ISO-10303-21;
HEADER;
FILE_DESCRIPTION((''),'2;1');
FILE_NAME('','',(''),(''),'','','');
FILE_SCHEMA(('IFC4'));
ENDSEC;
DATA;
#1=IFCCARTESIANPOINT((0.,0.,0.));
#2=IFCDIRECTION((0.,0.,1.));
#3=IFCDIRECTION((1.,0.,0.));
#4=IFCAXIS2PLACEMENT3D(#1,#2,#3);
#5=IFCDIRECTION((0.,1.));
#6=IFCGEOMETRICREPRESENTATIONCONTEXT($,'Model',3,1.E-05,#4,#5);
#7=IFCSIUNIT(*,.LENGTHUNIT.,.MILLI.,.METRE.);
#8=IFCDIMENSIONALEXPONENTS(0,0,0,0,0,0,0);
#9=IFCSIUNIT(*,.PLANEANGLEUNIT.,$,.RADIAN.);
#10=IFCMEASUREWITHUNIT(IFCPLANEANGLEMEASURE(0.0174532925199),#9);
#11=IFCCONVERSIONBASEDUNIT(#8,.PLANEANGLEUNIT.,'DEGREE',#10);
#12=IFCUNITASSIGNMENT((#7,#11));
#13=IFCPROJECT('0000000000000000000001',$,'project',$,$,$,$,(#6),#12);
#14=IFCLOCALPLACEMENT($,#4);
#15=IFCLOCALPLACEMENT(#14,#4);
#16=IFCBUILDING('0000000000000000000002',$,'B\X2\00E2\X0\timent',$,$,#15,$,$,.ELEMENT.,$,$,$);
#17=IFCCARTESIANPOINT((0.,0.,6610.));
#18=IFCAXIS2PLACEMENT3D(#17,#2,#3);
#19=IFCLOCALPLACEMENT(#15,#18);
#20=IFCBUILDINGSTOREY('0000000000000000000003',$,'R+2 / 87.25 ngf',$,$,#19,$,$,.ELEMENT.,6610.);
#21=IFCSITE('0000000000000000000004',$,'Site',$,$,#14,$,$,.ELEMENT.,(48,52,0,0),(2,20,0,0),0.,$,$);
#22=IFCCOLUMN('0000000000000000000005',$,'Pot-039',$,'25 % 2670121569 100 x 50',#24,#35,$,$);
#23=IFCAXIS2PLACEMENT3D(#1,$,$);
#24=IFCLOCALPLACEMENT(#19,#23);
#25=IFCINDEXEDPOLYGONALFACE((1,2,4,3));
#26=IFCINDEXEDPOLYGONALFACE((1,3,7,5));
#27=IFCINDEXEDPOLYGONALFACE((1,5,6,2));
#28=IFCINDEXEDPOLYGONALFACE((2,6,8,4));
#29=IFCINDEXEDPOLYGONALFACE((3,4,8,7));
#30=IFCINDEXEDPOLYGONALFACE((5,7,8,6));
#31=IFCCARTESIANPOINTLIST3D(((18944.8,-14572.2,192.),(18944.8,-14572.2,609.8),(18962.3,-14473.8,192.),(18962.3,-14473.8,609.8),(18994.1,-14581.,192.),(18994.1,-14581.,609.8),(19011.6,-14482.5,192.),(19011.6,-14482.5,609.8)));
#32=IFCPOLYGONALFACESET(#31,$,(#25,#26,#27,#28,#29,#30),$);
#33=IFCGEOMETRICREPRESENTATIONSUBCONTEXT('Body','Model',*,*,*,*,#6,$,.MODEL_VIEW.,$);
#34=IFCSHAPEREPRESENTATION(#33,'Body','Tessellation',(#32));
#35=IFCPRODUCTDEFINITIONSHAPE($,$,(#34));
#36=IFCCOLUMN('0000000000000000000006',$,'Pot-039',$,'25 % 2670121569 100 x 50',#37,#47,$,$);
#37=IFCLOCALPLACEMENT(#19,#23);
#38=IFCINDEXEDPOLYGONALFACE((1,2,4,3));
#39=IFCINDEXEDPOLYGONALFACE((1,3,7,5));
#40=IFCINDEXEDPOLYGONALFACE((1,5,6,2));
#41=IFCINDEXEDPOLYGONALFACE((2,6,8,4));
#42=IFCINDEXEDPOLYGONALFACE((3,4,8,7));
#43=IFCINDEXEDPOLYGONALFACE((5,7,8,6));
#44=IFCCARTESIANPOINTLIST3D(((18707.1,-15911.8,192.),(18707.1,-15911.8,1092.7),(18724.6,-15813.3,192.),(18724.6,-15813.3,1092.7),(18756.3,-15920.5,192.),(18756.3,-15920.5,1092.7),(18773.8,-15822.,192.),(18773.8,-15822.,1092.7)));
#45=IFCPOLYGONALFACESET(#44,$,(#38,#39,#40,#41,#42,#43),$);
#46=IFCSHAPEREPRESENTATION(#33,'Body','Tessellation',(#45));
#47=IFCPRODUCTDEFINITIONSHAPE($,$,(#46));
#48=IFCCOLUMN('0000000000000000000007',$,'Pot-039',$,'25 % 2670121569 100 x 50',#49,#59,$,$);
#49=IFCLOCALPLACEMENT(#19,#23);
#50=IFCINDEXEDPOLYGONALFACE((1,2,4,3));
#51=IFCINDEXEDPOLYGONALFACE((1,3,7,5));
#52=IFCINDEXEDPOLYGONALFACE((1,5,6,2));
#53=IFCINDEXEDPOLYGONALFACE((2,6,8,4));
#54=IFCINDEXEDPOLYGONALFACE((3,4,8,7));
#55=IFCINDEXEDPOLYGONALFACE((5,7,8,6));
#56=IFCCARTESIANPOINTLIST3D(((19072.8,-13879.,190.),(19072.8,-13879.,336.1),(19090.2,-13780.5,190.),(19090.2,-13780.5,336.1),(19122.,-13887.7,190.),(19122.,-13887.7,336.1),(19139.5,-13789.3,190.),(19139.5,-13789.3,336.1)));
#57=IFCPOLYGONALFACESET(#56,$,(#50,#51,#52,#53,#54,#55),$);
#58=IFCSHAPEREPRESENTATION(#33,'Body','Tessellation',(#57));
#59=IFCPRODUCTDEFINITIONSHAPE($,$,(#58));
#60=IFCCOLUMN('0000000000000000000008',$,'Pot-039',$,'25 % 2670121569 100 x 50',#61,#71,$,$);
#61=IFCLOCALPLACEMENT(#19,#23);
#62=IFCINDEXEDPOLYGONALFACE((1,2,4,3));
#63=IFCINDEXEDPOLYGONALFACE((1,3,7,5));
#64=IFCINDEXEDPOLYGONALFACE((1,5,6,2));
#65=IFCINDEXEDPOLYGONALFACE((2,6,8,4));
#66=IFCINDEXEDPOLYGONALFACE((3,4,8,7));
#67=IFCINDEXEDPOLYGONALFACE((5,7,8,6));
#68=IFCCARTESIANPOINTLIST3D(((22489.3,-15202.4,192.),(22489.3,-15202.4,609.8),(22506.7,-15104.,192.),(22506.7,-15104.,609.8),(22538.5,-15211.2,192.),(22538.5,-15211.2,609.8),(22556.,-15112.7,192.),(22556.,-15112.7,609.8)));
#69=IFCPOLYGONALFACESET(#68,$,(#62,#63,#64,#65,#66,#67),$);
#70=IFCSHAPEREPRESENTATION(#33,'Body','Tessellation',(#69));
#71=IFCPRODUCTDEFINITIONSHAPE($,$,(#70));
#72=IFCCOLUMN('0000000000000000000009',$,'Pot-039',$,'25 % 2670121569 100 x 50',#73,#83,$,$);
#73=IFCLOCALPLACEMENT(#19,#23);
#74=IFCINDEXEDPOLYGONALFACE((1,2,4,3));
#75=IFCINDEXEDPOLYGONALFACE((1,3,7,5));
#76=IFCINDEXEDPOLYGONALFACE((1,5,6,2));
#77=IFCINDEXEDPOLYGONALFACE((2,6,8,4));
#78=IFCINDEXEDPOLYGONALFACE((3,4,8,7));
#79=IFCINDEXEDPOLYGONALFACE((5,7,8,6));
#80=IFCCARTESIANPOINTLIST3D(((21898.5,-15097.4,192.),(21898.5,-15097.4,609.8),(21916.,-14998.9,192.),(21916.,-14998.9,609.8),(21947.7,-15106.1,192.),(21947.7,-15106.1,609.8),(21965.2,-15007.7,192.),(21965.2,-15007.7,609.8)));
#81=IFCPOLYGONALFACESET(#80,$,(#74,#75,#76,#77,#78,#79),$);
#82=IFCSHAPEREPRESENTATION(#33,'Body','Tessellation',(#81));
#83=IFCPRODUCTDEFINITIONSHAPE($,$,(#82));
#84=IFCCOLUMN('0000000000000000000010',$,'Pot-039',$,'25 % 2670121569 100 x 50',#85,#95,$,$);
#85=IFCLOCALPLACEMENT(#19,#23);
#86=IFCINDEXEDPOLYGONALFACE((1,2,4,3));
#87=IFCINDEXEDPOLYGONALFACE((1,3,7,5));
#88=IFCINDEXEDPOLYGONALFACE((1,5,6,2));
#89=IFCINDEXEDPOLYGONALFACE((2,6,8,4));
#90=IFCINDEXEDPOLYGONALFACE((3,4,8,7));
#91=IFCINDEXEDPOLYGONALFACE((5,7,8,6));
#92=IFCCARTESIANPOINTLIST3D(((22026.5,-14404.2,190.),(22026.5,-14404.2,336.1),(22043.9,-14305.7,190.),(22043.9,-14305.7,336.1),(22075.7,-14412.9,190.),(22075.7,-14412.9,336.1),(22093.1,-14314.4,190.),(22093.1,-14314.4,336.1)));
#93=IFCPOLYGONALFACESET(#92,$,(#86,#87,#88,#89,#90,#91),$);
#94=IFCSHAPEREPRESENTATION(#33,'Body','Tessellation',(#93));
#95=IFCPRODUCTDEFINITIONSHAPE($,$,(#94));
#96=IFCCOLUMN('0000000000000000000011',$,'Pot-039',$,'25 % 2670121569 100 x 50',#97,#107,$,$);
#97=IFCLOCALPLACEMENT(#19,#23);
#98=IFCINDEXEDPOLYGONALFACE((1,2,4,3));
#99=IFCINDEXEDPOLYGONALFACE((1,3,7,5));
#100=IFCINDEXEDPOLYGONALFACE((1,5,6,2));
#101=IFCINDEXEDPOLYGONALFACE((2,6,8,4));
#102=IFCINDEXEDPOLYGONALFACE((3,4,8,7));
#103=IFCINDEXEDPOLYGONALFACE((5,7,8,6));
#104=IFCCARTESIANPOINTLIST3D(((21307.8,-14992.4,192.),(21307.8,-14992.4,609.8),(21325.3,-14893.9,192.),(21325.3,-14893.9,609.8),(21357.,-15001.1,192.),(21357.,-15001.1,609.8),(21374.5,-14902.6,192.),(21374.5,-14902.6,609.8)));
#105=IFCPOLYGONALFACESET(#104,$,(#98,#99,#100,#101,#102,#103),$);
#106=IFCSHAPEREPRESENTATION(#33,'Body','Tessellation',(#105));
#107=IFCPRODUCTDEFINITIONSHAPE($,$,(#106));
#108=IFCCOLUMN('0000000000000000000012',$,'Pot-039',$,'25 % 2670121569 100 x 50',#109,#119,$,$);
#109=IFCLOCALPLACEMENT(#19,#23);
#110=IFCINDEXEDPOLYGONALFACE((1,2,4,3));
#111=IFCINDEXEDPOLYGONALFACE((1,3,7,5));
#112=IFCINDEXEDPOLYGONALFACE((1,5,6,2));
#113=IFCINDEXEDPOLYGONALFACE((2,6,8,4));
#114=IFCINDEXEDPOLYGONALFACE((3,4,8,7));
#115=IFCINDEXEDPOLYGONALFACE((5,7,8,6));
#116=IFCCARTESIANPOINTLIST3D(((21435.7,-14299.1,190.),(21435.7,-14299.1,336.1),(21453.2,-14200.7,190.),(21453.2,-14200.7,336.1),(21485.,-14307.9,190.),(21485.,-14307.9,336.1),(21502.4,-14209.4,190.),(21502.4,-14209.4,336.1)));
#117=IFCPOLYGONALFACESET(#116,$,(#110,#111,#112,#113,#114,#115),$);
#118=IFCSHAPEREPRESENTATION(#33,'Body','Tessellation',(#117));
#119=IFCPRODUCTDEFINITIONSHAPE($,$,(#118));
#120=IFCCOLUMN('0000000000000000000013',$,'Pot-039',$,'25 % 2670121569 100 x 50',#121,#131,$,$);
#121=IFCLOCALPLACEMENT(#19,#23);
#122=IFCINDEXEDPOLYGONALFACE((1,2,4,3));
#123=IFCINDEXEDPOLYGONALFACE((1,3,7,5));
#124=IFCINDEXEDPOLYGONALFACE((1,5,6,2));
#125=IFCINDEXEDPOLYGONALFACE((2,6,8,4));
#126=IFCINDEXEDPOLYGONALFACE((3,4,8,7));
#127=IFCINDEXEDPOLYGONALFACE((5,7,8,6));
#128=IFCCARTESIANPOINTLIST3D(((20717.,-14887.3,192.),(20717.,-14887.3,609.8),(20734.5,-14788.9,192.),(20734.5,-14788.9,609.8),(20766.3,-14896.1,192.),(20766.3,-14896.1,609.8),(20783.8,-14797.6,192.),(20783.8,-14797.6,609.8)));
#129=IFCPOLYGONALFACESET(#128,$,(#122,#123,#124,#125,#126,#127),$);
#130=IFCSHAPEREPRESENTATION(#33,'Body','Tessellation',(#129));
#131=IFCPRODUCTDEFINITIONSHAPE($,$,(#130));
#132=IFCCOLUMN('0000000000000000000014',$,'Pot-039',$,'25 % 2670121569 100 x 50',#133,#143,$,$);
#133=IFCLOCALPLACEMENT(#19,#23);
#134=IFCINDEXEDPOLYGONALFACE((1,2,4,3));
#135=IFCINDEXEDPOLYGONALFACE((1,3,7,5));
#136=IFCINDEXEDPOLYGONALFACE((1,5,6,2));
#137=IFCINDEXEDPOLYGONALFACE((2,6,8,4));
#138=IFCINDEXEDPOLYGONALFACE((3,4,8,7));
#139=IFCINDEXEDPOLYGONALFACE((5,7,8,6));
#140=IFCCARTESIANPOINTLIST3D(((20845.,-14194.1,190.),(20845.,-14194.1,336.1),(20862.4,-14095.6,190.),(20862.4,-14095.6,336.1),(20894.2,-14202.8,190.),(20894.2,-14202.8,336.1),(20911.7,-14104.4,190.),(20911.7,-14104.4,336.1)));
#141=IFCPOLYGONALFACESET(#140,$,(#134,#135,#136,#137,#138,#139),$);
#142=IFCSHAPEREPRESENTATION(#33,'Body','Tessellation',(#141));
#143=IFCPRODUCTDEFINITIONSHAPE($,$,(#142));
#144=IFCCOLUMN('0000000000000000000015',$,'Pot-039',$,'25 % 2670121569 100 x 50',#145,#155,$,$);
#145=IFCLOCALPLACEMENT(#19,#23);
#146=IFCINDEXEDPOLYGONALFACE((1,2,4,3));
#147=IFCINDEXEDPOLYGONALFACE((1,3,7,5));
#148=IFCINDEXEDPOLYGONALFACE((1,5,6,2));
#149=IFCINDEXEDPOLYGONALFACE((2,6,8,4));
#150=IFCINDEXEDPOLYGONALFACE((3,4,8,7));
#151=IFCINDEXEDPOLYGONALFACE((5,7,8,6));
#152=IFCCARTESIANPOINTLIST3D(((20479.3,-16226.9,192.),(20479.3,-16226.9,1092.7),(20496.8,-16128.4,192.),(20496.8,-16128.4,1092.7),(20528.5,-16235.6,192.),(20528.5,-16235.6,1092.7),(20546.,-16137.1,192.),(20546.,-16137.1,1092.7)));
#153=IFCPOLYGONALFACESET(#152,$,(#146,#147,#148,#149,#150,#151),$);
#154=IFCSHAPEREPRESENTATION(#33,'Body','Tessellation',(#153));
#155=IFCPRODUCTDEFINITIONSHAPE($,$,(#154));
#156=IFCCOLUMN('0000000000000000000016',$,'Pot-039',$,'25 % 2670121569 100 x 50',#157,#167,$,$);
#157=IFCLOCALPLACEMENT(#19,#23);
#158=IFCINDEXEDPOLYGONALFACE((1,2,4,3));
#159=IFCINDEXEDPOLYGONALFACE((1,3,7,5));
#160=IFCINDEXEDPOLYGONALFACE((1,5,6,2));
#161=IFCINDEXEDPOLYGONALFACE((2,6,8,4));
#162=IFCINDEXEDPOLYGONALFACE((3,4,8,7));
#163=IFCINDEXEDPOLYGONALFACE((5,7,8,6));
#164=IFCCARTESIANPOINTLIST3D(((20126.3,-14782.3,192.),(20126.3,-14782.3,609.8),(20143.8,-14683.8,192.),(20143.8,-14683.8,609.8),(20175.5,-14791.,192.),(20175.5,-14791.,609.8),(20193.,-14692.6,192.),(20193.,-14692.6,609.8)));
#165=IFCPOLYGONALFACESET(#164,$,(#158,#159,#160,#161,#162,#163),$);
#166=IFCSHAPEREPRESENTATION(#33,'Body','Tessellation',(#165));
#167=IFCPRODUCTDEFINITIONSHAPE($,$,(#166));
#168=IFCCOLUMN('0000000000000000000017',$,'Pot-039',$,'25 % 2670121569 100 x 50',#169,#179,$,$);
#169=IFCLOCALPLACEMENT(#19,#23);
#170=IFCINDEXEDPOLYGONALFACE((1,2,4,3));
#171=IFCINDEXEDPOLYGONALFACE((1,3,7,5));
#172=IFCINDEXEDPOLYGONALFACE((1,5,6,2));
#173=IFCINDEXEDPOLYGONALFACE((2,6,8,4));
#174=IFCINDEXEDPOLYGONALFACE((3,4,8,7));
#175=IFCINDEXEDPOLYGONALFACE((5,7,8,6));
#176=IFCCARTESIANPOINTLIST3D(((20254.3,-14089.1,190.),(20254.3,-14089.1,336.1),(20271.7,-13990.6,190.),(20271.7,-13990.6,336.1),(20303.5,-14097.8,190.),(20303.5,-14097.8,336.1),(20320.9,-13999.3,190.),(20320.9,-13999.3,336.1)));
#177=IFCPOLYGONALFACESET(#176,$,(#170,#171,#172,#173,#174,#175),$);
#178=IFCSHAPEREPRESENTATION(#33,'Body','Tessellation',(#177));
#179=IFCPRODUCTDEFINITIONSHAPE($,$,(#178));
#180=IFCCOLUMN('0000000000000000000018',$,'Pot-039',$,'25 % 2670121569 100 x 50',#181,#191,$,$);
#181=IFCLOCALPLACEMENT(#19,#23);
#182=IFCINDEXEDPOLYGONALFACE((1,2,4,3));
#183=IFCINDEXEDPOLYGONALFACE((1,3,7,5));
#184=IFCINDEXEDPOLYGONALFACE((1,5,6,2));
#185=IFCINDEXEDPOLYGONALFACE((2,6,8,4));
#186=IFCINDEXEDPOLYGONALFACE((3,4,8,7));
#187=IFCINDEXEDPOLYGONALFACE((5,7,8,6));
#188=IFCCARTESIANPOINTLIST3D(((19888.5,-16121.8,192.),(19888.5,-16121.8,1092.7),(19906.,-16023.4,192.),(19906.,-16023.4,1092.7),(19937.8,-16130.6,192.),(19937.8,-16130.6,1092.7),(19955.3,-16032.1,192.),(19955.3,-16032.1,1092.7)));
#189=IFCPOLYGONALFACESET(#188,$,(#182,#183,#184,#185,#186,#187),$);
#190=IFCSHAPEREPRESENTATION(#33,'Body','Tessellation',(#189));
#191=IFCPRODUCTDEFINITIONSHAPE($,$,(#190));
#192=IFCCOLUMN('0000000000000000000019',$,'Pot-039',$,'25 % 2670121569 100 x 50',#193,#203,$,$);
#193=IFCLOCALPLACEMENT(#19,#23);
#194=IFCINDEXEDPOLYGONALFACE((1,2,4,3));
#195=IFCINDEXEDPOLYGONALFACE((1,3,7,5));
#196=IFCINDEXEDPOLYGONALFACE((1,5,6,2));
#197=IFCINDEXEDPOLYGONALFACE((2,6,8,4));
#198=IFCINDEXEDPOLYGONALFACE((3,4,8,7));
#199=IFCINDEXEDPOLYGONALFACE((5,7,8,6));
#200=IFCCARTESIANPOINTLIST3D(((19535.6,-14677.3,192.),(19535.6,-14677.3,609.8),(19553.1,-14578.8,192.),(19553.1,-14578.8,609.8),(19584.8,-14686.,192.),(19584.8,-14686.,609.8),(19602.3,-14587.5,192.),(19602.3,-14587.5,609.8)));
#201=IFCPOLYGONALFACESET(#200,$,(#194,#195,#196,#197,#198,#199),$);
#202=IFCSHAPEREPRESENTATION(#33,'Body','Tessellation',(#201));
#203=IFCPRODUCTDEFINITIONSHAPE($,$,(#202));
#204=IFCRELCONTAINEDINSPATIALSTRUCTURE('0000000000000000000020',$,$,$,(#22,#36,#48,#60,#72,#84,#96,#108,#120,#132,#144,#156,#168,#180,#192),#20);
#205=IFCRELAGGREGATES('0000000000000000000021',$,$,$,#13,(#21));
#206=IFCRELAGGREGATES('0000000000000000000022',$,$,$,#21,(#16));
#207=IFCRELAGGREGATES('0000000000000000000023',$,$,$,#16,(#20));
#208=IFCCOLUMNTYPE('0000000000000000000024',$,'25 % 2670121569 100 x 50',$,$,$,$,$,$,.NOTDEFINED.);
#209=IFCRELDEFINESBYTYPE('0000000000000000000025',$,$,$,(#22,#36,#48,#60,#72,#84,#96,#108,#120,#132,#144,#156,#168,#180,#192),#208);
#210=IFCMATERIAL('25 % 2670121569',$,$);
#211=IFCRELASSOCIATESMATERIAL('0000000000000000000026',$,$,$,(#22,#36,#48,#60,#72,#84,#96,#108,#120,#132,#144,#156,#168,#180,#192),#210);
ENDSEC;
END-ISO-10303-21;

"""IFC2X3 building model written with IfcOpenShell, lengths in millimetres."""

from ifc_helpers import new_model, entity, si_unit, converted_unit, direction, frame, origin_with_axes, origin_2d_with_axis, place, context, subcontext, project, spatial, rectangle, extrude, material, type_object, element, save


model = new_model("IFC2X3")

# Units and contexts
model_context = context("Model", 3, precision=1e-05, world=origin_with_axes(), true_north=direction((0.0, 1.0)))
body_context = subcontext(model_context, "Body", "Model", "MODEL_VIEW")
ifc_project = project(units=[si_unit("LENGTHUNIT", "METRE", prefix="MILLI"), converted_unit("PLANEANGLEUNIT", "DEGREE", entity("IfcPlaneAngleMeasure", 0.0174532925199), si_unit("PLANEANGLEUNIT", "RADIAN"), dimensions=[0, 0, 0, 0, 0, 0, 0])], contexts=[model_context])

# Site, building, storey
site_placement = place(None, origin_with_axes())
site = spatial("IfcSite", under=ifc_project, at=site_placement, Name="Site", CompositionType="ELEMENT", RefLatitude=(48, 52, 0, 0), RefLongitude=(2, 20, 0, 0), RefElevation=0.0)
building_placement = place(site_placement, origin_with_axes())
building = spatial("IfcBuilding", under=site, at=building_placement, Name="Bâtiment", CompositionType="ELEMENT")
storey_placement = place(building_placement, frame((0.0, 0.0, 6610.0), z_axis=(0.0, 0.0, 1.0), x_axis=(1.0, 0.0, 0.0)))
storey = spatial("IfcBuildingStorey", under=building, at=storey_placement, Name="R+2 / 87.25 ngf", CompositionType="ELEMENT", Elevation=6610.0)

# Columns
ifc_material_1 = material(Name="25 % 2670121569")
column_type = type_object("IfcColumnType", Name="25 % 2670121569 100 x 50", PredefinedType="NOTDEFINED")
column_1_placement = place(storey_placement, frame((18978.2, -14527.4, 192.0), z_axis=(0.0, 0.0, 1.0), x_axis=(0.17478, 0.984607, 0.0)))
element("IfcColumn", 1, at=column_1_placement, inside=storey, type_object=column_type, material=ifc_material_1, Name="Pot-039", ObjectType="25 % 2670121569 100 x 50", context=body_context, shape_type="SweptSolid", body=[
    extrude(rectangle(XDim=100.0, YDim=50.0, at=origin_2d_with_axis()), origin_with_axes(), (0.0, 0.0, 1.0), 417.8),
])
column_2_placement = place(storey_placement, frame((18740.4, -15866.9, 192.0), z_axis=(0.0, 0.0, 1.0), x_axis=(0.17478, 0.984607, 0.0)))
element("IfcColumn", 2, at=column_2_placement, inside=storey, type_object=column_type, material=ifc_material_1, Name="Pot-039", ObjectType="25 % 2670121569 100 x 50", context=body_context, shape_type="SweptSolid", body=[
    extrude(rectangle(XDim=100.0, YDim=50.0, at=origin_2d_with_axis()), origin_with_axes(), (0.0, 0.0, 1.0), 900.7),
])
column_3_placement = place(storey_placement, frame((19106.1, -13834.1, 190.0), z_axis=(0.0, 0.0, 1.0), x_axis=(0.174407, 0.984674, 0.0)))
element("IfcColumn", 3, at=column_3_placement, inside=storey, type_object=column_type, material=ifc_material_1, Name="Pot-039", ObjectType="25 % 2670121569 100 x 50", context=body_context, shape_type="SweptSolid", body=[
    extrude(rectangle(XDim=100.0, YDim=50.0, at=origin_2d_with_axis()), origin_with_axes(), (0.0, 0.0, 1.0), 146.1),
])
for number, where, z_axis, x_axis, name in (
    (4, (22522.6, -15157.6, 192.0), (0.0, 0.0, 1.0), (0.17478, 0.984607, 0.0), "Pot-039"),
    (5, (21931.9, -15052.5, 192.0), (0.0, 0.0, 1.0), (0.17478, 0.984607, 0.0), "Pot-039"),
):
    element("IfcColumn", number, at=place(storey_placement, frame(where, z_axis=z_axis, x_axis=x_axis)), inside=storey, type_object=column_type, material=ifc_material_1, Name=name, ObjectType="25 % 2670121569 100 x 50", context=body_context, shape_type="SweptSolid", body=[
        extrude(rectangle(XDim=100.0, YDim=50.0, at=origin_2d_with_axis()), origin_with_axes(), (0.0, 0.0, 1.0), 417.8),
    ])
column_4_placement = place(storey_placement, frame((22059.8, -14359.3, 190.0), z_axis=(0.0, 0.0, 1.0), x_axis=(0.174407, 0.984674, 0.0)))
element("IfcColumn", 6, at=column_4_placement, inside=storey, type_object=column_type, material=ifc_material_1, Name="Pot-039", ObjectType="25 % 2670121569 100 x 50", context=body_context, shape_type="SweptSolid", body=[
    extrude(rectangle(XDim=100.0, YDim=50.0, at=origin_2d_with_axis()), origin_with_axes(), (0.0, 0.0, 1.0), 146.1),
])
column_5_placement = place(storey_placement, frame((21341.1, -14947.5, 192.0), z_axis=(0.0, 0.0, 1.0), x_axis=(0.17478, 0.984607, 0.0)))
element("IfcColumn", 7, at=column_5_placement, inside=storey, type_object=column_type, material=ifc_material_1, Name="Pot-039", ObjectType="25 % 2670121569 100 x 50", context=body_context, shape_type="SweptSolid", body=[
    extrude(rectangle(XDim=100.0, YDim=50.0, at=origin_2d_with_axis()), origin_with_axes(), (0.0, 0.0, 1.0), 417.8),
])
column_6_placement = place(storey_placement, frame((21469.1, -14254.3, 190.0), z_axis=(0.0, 0.0, 1.0), x_axis=(0.174407, 0.984674, 0.0)))
element("IfcColumn", 8, at=column_6_placement, inside=storey, type_object=column_type, material=ifc_material_1, Name="Pot-039", ObjectType="25 % 2670121569 100 x 50", context=body_context, shape_type="SweptSolid", body=[
    extrude(rectangle(XDim=100.0, YDim=50.0, at=origin_2d_with_axis()), origin_with_axes(), (0.0, 0.0, 1.0), 146.1),
])
column_7_placement = place(storey_placement, frame((20750.4, -14842.5, 192.0), z_axis=(0.0, 0.0, 1.0), x_axis=(0.17478, 0.984607, 0.0)))
element("IfcColumn", 9, at=column_7_placement, inside=storey, type_object=column_type, material=ifc_material_1, Name="Pot-039", ObjectType="25 % 2670121569 100 x 50", context=body_context, shape_type="SweptSolid", body=[
    extrude(rectangle(XDim=100.0, YDim=50.0, at=origin_2d_with_axis()), origin_with_axes(), (0.0, 0.0, 1.0), 417.8),
])
column_8_placement = place(storey_placement, frame((20878.3, -14149.2, 190.0), z_axis=(0.0, 0.0, 1.0), x_axis=(0.174407, 0.984674, 0.0)))
element("IfcColumn", 10, at=column_8_placement, inside=storey, type_object=column_type, material=ifc_material_1, Name="Pot-039", ObjectType="25 % 2670121569 100 x 50", context=body_context, shape_type="SweptSolid", body=[
    extrude(rectangle(XDim=100.0, YDim=50.0, at=origin_2d_with_axis()), origin_with_axes(), (0.0, 0.0, 1.0), 146.1),
])
column_9_placement = place(storey_placement, frame((20512.6, -16182.0, 192.0), z_axis=(0.0, 0.0, 1.0), x_axis=(0.17478, 0.984607, 0.0)))
element("IfcColumn", 11, at=column_9_placement, inside=storey, type_object=column_type, material=ifc_material_1, Name="Pot-039", ObjectType="25 % 2670121569 100 x 50", context=body_context, shape_type="SweptSolid", body=[
    extrude(rectangle(XDim=100.0, YDim=50.0, at=origin_2d_with_axis()), origin_with_axes(), (0.0, 0.0, 1.0), 900.7),
])
column_10_placement = place(storey_placement, frame((20159.7, -14737.4, 192.0), z_axis=(0.0, 0.0, 1.0), x_axis=(0.17478, 0.984607, 0.0)))
element("IfcColumn", 12, at=column_10_placement, inside=storey, type_object=column_type, material=ifc_material_1, Name="Pot-039", ObjectType="25 % 2670121569 100 x 50", context=body_context, shape_type="SweptSolid", body=[
    extrude(rectangle(XDim=100.0, YDim=50.0, at=origin_2d_with_axis()), origin_with_axes(), (0.0, 0.0, 1.0), 417.8),
])
column_11_placement = place(storey_placement, frame((20287.6, -14044.2, 190.0), z_axis=(0.0, 0.0, 1.0), x_axis=(0.174407, 0.984674, 0.0)))
element("IfcColumn", 13, at=column_11_placement, inside=storey, type_object=column_type, material=ifc_material_1, Name="Pot-039", ObjectType="25 % 2670121569 100 x 50", context=body_context, shape_type="SweptSolid", body=[
    extrude(rectangle(XDim=100.0, YDim=50.0, at=origin_2d_with_axis()), origin_with_axes(), (0.0, 0.0, 1.0), 146.1),
])
column_12_placement = place(storey_placement, frame((19921.9, -16077.0, 192.0), z_axis=(0.0, 0.0, 1.0), x_axis=(0.17478, 0.984607, 0.0)))
element("IfcColumn", 14, at=column_12_placement, inside=storey, type_object=column_type, material=ifc_material_1, Name="Pot-039", ObjectType="25 % 2670121569 100 x 50", context=body_context, shape_type="SweptSolid", body=[
    extrude(rectangle(XDim=100.0, YDim=50.0, at=origin_2d_with_axis()), origin_with_axes(), (0.0, 0.0, 1.0), 900.7),
])
column_13_placement = place(storey_placement, frame((19568.9, -14632.4, 192.0), z_axis=(0.0, 0.0, 1.0), x_axis=(0.17478, 0.984607, 0.0)))
element("IfcColumn", 15, at=column_13_placement, inside=storey, type_object=column_type, material=ifc_material_1, Name="Pot-039", ObjectType="25 % 2670121569 100 x 50", context=body_context, shape_type="SweptSolid", body=[
    extrude(rectangle(XDim=100.0, YDim=50.0, at=origin_2d_with_axis()), origin_with_axes(), (0.0, 0.0, 1.0), 417.8),
])

save(model, "model.ifc")
